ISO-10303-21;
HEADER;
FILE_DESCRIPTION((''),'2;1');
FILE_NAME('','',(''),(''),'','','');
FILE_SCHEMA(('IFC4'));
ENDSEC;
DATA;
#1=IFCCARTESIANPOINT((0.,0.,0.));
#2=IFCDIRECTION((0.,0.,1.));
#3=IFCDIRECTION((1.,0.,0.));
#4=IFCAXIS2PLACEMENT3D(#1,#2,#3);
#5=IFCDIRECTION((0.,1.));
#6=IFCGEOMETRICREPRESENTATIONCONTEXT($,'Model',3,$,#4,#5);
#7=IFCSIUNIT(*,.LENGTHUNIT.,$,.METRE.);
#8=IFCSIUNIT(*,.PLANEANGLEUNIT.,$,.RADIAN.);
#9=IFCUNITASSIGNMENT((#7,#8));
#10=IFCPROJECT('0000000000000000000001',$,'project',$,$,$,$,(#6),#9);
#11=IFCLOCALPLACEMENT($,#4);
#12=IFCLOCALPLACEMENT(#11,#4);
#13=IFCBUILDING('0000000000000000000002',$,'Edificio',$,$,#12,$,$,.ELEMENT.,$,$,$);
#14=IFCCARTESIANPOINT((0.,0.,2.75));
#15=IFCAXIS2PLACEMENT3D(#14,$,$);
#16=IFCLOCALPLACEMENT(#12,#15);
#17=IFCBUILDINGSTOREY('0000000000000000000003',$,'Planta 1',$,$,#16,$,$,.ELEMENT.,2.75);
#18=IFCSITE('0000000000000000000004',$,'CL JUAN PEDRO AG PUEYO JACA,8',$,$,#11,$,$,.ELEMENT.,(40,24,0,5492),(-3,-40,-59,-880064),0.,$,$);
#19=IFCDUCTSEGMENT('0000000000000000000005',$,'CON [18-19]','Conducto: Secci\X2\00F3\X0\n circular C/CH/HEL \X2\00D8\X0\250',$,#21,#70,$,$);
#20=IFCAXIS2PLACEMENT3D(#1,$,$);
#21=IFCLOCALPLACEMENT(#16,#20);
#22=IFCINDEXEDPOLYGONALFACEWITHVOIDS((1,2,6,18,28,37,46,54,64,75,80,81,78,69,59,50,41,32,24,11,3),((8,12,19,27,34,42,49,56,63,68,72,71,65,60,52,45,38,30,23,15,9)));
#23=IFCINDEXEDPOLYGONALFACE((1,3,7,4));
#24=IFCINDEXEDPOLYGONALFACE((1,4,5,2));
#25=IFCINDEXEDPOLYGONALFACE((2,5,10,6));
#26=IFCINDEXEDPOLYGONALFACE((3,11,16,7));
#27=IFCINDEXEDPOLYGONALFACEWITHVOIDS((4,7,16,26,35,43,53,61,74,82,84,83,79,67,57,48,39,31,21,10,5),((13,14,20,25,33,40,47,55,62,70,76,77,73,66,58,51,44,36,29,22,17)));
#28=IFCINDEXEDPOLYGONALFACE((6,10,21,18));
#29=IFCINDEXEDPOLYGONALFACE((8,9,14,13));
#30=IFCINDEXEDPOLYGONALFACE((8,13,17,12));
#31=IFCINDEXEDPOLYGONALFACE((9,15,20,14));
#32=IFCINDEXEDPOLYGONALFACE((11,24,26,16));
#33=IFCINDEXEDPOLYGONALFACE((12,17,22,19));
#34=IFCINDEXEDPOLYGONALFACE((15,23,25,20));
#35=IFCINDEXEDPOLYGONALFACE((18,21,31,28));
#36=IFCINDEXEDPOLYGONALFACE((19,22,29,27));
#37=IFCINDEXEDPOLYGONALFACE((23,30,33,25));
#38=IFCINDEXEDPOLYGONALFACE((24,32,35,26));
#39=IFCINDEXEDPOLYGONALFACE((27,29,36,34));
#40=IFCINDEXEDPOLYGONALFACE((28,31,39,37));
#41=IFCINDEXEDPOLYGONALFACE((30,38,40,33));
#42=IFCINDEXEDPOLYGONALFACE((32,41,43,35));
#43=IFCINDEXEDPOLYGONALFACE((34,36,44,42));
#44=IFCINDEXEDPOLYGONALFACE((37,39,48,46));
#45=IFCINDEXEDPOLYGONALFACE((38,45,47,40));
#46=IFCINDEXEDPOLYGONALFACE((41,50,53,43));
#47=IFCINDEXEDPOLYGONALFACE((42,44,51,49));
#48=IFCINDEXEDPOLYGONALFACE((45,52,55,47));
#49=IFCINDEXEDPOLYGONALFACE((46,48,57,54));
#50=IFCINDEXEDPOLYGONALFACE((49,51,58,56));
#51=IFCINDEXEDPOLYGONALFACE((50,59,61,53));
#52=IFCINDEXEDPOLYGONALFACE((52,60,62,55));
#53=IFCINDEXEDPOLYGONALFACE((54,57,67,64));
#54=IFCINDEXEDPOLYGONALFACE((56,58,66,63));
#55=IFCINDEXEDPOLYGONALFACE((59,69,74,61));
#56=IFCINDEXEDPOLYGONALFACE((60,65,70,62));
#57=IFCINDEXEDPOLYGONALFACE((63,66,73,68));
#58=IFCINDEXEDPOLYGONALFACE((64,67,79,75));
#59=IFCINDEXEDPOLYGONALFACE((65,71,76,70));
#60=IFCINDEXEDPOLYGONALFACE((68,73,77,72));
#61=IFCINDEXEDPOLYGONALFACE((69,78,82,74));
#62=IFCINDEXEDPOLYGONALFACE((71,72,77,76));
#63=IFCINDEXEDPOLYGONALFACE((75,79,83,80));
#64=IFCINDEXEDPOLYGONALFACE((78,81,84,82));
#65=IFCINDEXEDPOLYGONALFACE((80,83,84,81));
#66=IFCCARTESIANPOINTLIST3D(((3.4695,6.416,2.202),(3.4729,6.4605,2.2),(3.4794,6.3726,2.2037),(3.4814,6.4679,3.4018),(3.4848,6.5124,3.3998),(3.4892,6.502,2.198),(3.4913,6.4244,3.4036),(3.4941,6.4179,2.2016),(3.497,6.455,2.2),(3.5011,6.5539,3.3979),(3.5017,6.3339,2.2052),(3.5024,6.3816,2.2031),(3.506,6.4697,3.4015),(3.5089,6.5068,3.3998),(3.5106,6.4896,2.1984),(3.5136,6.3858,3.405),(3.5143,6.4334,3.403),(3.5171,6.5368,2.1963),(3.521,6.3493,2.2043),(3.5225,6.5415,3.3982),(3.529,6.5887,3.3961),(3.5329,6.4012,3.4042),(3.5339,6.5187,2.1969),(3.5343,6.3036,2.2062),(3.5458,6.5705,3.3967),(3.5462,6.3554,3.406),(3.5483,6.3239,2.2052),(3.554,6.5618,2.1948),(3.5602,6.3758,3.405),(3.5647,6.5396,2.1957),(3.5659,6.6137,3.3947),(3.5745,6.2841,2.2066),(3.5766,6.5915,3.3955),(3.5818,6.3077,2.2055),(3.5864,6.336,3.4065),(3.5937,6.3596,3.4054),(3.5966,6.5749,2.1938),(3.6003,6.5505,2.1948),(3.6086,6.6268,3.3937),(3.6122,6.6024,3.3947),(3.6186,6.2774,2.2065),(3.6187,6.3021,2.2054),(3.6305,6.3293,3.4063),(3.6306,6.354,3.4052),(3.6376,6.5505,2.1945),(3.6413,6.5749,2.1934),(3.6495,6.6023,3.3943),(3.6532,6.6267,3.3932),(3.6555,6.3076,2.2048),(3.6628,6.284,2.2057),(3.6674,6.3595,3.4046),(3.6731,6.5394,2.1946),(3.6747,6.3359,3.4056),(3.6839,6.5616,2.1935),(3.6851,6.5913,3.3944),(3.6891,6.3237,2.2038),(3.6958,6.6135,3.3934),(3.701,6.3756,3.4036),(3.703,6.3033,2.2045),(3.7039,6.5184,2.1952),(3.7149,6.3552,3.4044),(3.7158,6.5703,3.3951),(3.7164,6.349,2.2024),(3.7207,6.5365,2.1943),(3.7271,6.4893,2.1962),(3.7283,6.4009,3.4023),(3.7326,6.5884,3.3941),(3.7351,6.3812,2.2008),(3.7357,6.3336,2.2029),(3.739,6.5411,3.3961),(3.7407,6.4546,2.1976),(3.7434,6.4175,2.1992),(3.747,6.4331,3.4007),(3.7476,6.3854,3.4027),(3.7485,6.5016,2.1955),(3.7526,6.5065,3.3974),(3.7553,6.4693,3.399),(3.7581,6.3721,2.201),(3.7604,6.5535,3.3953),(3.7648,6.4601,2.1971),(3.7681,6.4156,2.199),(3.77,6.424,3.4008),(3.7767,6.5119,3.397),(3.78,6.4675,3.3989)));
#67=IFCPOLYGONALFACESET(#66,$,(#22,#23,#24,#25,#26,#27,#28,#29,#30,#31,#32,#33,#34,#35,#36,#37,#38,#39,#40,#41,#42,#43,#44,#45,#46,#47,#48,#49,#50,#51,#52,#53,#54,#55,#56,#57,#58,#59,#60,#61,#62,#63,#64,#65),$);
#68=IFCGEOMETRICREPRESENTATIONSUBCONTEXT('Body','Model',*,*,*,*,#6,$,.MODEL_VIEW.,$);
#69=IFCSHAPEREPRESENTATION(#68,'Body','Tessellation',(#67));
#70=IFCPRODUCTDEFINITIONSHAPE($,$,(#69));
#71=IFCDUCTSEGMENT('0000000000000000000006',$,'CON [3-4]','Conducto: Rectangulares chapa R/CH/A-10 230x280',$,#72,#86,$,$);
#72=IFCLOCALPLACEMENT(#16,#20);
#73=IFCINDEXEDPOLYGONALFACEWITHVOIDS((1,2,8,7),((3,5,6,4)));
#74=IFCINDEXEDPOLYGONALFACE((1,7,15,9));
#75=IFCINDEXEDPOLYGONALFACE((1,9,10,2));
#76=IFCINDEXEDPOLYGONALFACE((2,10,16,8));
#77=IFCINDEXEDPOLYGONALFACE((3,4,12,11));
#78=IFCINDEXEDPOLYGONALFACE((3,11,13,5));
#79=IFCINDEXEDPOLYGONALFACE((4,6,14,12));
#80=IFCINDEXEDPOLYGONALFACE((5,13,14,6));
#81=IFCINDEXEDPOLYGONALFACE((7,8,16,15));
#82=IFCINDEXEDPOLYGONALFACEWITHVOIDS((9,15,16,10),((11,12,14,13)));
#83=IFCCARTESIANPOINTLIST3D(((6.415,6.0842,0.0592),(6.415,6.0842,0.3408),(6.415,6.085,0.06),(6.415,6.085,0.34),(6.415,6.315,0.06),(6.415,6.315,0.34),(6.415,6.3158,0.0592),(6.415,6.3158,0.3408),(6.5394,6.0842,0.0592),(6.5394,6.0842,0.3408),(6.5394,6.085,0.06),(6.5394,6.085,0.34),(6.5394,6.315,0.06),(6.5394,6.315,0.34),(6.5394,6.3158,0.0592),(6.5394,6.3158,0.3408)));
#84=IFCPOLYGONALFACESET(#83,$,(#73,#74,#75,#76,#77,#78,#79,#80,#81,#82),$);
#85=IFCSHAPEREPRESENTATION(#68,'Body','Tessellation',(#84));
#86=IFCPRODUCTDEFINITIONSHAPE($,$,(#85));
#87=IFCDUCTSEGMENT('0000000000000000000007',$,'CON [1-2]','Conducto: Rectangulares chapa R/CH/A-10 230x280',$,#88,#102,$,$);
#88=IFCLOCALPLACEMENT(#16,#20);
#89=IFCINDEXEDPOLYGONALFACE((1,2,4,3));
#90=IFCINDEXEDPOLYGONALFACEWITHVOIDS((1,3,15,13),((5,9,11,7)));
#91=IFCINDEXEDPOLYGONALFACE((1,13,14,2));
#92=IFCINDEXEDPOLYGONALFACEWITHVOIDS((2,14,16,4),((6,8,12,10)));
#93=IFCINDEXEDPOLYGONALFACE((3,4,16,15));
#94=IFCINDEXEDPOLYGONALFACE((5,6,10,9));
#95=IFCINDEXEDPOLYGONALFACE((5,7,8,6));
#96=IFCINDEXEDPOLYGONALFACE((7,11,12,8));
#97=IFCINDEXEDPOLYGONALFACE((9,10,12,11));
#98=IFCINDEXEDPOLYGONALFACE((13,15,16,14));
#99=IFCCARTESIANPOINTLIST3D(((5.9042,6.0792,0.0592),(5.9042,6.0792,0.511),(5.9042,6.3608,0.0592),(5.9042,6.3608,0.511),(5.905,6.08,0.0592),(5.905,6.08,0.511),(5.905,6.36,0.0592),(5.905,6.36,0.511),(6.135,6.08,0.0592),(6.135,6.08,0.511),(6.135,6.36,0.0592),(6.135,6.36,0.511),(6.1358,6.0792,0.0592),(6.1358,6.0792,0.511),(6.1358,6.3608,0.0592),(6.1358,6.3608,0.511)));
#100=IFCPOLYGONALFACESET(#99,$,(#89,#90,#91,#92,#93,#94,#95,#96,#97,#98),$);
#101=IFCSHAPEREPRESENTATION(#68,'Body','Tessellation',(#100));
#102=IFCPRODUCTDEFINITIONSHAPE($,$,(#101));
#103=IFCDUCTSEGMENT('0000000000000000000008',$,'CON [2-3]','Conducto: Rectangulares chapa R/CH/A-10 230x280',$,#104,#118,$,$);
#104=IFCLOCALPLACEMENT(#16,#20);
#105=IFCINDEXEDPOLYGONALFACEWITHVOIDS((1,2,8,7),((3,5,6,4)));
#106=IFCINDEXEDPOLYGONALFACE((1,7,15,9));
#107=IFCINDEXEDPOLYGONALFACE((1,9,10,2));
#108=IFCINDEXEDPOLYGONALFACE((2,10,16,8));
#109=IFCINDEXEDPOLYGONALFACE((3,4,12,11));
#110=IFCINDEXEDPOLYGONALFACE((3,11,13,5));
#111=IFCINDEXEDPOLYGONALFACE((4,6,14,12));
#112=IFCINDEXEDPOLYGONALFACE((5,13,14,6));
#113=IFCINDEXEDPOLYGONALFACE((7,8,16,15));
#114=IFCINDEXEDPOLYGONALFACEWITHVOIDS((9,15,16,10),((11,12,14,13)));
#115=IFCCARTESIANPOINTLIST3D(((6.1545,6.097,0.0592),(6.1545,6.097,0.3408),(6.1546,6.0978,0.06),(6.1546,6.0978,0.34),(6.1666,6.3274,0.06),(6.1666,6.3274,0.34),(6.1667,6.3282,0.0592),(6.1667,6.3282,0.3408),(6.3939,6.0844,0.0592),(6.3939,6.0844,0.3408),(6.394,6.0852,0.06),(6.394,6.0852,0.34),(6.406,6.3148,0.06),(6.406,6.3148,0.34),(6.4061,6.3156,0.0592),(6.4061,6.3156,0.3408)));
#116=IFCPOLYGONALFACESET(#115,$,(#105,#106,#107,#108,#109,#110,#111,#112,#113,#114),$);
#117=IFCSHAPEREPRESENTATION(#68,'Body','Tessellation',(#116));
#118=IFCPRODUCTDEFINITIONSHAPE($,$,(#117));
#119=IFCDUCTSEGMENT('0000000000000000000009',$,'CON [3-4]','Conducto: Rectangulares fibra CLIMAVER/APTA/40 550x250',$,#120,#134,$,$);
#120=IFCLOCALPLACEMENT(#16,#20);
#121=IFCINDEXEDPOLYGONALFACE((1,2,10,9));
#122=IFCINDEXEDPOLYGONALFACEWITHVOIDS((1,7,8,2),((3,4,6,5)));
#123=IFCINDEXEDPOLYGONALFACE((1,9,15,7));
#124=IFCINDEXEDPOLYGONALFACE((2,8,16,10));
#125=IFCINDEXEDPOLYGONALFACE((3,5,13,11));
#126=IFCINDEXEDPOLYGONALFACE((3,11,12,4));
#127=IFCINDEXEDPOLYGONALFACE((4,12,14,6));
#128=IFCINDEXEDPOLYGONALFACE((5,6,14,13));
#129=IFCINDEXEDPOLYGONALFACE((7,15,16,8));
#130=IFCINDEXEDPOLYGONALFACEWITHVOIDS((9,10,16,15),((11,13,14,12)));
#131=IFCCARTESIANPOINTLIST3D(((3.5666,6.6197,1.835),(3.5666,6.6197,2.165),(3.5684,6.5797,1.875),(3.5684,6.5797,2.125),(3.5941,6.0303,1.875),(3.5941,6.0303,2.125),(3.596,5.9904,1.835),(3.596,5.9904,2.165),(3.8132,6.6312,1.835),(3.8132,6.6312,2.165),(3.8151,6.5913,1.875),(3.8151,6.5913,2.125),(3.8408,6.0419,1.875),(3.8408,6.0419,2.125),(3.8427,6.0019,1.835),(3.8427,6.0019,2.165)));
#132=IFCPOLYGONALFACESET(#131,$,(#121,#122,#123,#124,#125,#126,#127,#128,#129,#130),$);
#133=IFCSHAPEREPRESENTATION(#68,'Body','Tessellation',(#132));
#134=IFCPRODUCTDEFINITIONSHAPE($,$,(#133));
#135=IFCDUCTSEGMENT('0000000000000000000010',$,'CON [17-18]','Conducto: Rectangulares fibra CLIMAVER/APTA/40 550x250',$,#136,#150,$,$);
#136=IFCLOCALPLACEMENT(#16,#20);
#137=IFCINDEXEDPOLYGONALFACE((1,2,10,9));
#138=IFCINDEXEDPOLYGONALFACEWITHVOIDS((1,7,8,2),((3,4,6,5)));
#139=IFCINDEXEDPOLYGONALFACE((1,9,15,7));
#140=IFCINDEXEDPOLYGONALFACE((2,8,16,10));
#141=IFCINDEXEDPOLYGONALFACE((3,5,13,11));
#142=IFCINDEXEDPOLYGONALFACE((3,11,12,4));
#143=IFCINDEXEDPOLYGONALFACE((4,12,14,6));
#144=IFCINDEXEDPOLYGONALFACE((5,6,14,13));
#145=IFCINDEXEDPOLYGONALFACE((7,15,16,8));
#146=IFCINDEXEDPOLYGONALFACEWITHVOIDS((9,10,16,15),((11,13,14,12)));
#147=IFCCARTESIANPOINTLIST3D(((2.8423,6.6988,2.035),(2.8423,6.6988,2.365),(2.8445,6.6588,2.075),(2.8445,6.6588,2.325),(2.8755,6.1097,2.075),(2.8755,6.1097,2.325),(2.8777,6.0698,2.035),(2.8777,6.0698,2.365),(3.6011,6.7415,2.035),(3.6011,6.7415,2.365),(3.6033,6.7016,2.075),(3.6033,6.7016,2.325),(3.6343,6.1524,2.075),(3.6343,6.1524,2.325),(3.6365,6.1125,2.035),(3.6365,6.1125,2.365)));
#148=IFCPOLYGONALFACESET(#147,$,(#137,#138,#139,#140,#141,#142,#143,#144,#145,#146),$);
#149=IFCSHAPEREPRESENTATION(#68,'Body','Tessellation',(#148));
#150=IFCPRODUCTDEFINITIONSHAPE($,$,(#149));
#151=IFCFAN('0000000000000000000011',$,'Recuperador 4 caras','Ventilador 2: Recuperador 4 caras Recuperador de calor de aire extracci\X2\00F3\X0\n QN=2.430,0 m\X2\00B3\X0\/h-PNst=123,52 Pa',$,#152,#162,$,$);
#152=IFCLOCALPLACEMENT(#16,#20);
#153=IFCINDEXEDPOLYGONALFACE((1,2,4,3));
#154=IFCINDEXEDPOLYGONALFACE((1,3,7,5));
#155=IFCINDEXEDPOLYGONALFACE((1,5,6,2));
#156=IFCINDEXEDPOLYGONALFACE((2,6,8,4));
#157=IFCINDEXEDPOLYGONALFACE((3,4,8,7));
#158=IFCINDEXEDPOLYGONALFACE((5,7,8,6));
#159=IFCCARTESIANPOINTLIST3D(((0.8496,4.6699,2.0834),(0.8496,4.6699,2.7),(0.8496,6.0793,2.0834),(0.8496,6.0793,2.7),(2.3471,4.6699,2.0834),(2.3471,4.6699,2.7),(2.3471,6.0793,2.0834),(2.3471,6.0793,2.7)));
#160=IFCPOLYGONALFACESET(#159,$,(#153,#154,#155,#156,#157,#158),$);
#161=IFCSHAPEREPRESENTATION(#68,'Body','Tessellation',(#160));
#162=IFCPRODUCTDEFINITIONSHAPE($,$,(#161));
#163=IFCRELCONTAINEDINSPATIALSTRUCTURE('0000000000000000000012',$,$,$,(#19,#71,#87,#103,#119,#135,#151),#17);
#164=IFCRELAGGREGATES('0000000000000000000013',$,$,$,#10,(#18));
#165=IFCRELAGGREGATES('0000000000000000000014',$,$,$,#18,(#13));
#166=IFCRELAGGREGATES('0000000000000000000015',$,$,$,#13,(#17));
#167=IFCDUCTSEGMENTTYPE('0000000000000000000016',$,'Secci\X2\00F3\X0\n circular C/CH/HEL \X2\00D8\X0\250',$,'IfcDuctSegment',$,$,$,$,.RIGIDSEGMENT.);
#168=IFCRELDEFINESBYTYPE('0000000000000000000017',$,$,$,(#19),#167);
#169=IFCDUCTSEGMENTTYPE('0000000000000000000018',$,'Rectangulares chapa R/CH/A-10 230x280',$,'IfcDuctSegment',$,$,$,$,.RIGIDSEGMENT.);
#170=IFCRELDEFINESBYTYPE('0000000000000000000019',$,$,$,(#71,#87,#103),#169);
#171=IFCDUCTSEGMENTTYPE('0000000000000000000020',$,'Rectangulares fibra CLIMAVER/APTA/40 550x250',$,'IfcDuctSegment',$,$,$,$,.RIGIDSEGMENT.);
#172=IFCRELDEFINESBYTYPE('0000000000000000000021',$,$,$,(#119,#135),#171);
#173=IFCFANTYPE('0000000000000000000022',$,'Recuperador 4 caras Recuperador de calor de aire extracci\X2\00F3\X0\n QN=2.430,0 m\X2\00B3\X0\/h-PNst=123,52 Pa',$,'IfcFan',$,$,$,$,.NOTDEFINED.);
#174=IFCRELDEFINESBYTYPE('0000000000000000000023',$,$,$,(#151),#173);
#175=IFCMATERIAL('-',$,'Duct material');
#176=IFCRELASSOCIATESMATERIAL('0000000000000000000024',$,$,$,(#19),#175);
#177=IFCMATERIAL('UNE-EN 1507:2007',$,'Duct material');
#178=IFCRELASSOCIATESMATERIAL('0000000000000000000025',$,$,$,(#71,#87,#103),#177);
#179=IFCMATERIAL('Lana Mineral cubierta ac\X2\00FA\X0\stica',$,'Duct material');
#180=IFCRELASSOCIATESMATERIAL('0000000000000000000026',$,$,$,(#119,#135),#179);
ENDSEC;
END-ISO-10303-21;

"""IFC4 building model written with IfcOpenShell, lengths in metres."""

from ifc_helpers import new_model, si_unit, direction, frame, origin_with_axes, origin_2d_with_axis, place, context, subcontext, project, spatial, polyline, hollow_rectangle, hollow_circle, outline, extrude, source, transform, mapped, material, type_object, element, save


model = new_model("IFC4")

# Units and contexts
model_context = context("Model", 3, world=origin_with_axes(), true_north=direction((0.0, 1.0)))
body_context = subcontext(model_context, "Body", "Model", "MODEL_VIEW")
ifc_project = project(units=[si_unit("LENGTHUNIT", "METRE"), si_unit("PLANEANGLEUNIT", "RADIAN")], contexts=[model_context])

# Site, building, storey
site_placement = place(None, origin_with_axes())
site = spatial("IfcSite", under=ifc_project, at=site_placement, Name="CL JUAN PEDRO AG PUEYO JACA,8", CompositionType="ELEMENT", RefLatitude=(40, 24, 0, 5492), RefLongitude=(-3, -40, -59, -880064), RefElevation=0.0)
building_placement = place(site_placement, origin_with_axes())
building = spatial("IfcBuilding", under=site, at=building_placement, Name="Edificio", CompositionType="ELEMENT")
storey_placement = place(building_placement, frame((0.0, 0.0, 2.75)))
storey = spatial("IfcBuildingStorey", under=building, at=storey_placement, Name="Planta 1", CompositionType="ELEMENT", Elevation=2.75)

# Shared definitions
ifc_material_1 = material(Name="-", Category="Duct material")

# Duct segment
ifc_material_2 = material(Name="UNE-EN 1507:2007", Category="Duct material")
duct_segment_type_1 = type_object("IfcDuctSegmentType", Name="Sección circular C/CH/HEL Ø250", ApplicableOccurrence="IfcDuctSegment", PredefinedType="RIGIDSEGMENT")
duct_segment_1_placement = place(storey_placement, frame((0.0, 0.0, -2.75), z_axis=(0.0, 0.0, 1.0), x_axis=(1.0, 0.0, 0.0)))
element("IfcDuctSegment", 1, at=duct_segment_1_placement, inside=storey, type_object=duct_segment_type_1, material=ifc_material_1, Name="CON [18-19]", Description="Conducto: Sección circular C/CH/HEL Ø250", context=body_context, shape_type="SweptSolid", body=[
    extrude(hollow_circle(Radius=0.1497, WallThickness=0.0247, at=origin_2d_with_axis()), frame((3.6188, 6.427, 4.95), z_axis=(0.009918, 0.043192, 0.999018), x_axis=(-0.974634, 0.223805, 0.0)), (0.0, 0.0, 1.0), 1.201),
])

# Duct segments
duct_segment_type_2 = type_object("IfcDuctSegmentType", Name="Rectangulares chapa R/CH/A-10 230x280", ApplicableOccurrence="IfcDuctSegment", PredefinedType="RIGIDSEGMENT")
duct_segment_2_placement = place(storey_placement, frame((0.0, 0.0, -2.75), z_axis=(0.0, 0.0, 1.0), x_axis=(1.0, 0.0, 0.0)))
element("IfcDuctSegment", 2, at=duct_segment_2_placement, inside=storey, type_object=duct_segment_type_2, material=ifc_material_2, Name="CON [3-4]", Description="Conducto: Rectangulares chapa R/CH/A-10 230x280", context=body_context, shape_type="SweptSolid", body=[
    extrude(hollow_rectangle(XDim=0.2316, YDim=0.2816, WallThickness=0.0008, at=origin_2d_with_axis()), frame((6.415, 6.2, 2.95), z_axis=(1.0, 0.0, 0.0), x_axis=(0.0, 1.0, 0.0)), (0.0, 0.0, 1.0), 0.1244),
])
duct_segment_3_placement = place(storey_placement, frame((0.0, 0.0, -2.75), z_axis=(0.0, 0.0, 1.0), x_axis=(1.0, 0.0, 0.0)))
element("IfcDuctSegment", 3, at=duct_segment_3_placement, inside=storey, type_object=duct_segment_type_2, material=ifc_material_2, Name="CON [1-2]", Description="Conducto: Rectangulares chapa R/CH/A-10 230x280", context=body_context, shape_type="SweptSolid", body=[
    extrude(hollow_rectangle(XDim=0.2316, YDim=0.2816, WallThickness=0.0008, at=origin_2d_with_axis()), frame((6.02, 6.22, 3.261), z_axis=(0.0, 0.0, -1.0), x_axis=(-1.0, 0.0, 0.0)), (0.0, 0.0, 1.0), 0.4518),
])
duct_segment_4_placement = place(storey_placement, frame((0.0, 0.0, -2.75), z_axis=(0.0, 0.0, 1.0), x_axis=(1.0, 0.0, 0.0)))
element("IfcDuctSegment", 4, at=duct_segment_4_placement, inside=storey, type_object=duct_segment_type_2, material=ifc_material_2, Name="CON [2-3]", Description="Conducto: Rectangulares chapa R/CH/A-10 230x280", context=body_context, shape_type="SweptSolid", body=[
    extrude(hollow_rectangle(XDim=0.2316, YDim=0.2816, WallThickness=0.0008, at=origin_2d_with_axis()), frame((6.1606, 6.2126, 2.95), z_axis=(0.998618, -0.052559, 0.0), x_axis=(0.052559, 0.998618, 0.0)), (0.0, 0.0, 1.0), 0.2397),
])

# Duct segments
ifc_material_3 = material(Name="Lana Mineral cubierta acústica", Category="Duct material")
duct_segment_type_3 = type_object("IfcDuctSegmentType", Name="Rectangulares fibra CLIMAVER/APTA/40 550x250", ApplicableOccurrence="IfcDuctSegment", PredefinedType="RIGIDSEGMENT")
duct_segment_5_placement = place(storey_placement, frame((0.0, 0.0, -2.75), z_axis=(0.0, 0.0, 1.0), x_axis=(1.0, 0.0, 0.0)))
element("IfcDuctSegment", 5, at=duct_segment_5_placement, inside=storey, type_object=duct_segment_type_3, material=ifc_material_3, Name="CON [3-4]", Description="Conducto: Rectangulares fibra CLIMAVER/APTA/40 550x250", context=body_context, shape_type="SweptSolid", body=[
    extrude(hollow_rectangle(XDim=0.63, YDim=0.33, WallThickness=0.04, at=origin_2d_with_axis()), frame((3.5813, 6.305, 4.75), z_axis=(0.998907, 0.046731, 0.0), x_axis=(-0.046731, 0.998907, 0.0)), (0.0, 0.0, 1.0), 0.2469),
])
duct_segment_6_placement = place(storey_placement, frame((0.0, 0.0, -2.75), z_axis=(0.0, 0.0, 1.0), x_axis=(1.0, 0.0, 0.0)))
element("IfcDuctSegment", 6, at=duct_segment_6_placement, inside=storey, type_object=duct_segment_type_3, material=ifc_material_3, Name="CON [17-18]", Description="Conducto: Rectangulares fibra CLIMAVER/APTA/40 550x250", context=body_context, shape_type="SweptSolid", body=[
    extrude(hollow_rectangle(XDim=0.63, YDim=0.33, WallThickness=0.04, at=origin_2d_with_axis()), frame((2.86, 6.3843, 4.95), z_axis=(0.998417, 0.056242, 0.0), x_axis=(-0.056242, 0.998417, 0.0)), (0.0, 0.0, 1.0), 0.76),
])

# Fan
fan_type_1 = type_object("IfcFanType", Name="Recuperador 4 caras Recuperador de calor de aire extracción QN=2.430,0 m³/h-PNst=123,52 Pa", ApplicableOccurrence="IfcFan", PredefinedType="NOTDEFINED")
shared_shape_1 = source(origin_with_axes(), body_context, "Body", "SweptSolid", [
    extrude(outline(polyline([(-1.4975, 0.0), (0.0, 0.0), (0.0, 1.4094), (-1.4975, 1.4094), (-1.4975, 0.0)])), frame((0.0, 0.0, -0.6166), z_axis=(0.0, 0.0, 1.0), x_axis=(1.0, 0.0, 0.0)), (0.0, 0.0, 1.0), 0.6166),
])
fan_1_placement = place(storey_placement, origin_with_axes())
element("IfcFan", 7, at=fan_1_placement, inside=storey, type_object=fan_type_1, Name="Recuperador 4 caras", Description="Ventilador 2: Recuperador 4 caras Recuperador de calor de aire extracción QN=2.430,0 m³/h-PNst=123,52 Pa", context=body_context, shape_type="MappedRepresentation", body=[
    mapped(shared_shape_1, transform((2.3471, 4.6699, 2.7), x_axis=(1.0, 0.0, 0.0), y_axis=(0.0, 1.0, 0.0), z_axis=(0.0, 0.0, 1.0), scale=1.0)),
])

save(model, "model.ifc")
